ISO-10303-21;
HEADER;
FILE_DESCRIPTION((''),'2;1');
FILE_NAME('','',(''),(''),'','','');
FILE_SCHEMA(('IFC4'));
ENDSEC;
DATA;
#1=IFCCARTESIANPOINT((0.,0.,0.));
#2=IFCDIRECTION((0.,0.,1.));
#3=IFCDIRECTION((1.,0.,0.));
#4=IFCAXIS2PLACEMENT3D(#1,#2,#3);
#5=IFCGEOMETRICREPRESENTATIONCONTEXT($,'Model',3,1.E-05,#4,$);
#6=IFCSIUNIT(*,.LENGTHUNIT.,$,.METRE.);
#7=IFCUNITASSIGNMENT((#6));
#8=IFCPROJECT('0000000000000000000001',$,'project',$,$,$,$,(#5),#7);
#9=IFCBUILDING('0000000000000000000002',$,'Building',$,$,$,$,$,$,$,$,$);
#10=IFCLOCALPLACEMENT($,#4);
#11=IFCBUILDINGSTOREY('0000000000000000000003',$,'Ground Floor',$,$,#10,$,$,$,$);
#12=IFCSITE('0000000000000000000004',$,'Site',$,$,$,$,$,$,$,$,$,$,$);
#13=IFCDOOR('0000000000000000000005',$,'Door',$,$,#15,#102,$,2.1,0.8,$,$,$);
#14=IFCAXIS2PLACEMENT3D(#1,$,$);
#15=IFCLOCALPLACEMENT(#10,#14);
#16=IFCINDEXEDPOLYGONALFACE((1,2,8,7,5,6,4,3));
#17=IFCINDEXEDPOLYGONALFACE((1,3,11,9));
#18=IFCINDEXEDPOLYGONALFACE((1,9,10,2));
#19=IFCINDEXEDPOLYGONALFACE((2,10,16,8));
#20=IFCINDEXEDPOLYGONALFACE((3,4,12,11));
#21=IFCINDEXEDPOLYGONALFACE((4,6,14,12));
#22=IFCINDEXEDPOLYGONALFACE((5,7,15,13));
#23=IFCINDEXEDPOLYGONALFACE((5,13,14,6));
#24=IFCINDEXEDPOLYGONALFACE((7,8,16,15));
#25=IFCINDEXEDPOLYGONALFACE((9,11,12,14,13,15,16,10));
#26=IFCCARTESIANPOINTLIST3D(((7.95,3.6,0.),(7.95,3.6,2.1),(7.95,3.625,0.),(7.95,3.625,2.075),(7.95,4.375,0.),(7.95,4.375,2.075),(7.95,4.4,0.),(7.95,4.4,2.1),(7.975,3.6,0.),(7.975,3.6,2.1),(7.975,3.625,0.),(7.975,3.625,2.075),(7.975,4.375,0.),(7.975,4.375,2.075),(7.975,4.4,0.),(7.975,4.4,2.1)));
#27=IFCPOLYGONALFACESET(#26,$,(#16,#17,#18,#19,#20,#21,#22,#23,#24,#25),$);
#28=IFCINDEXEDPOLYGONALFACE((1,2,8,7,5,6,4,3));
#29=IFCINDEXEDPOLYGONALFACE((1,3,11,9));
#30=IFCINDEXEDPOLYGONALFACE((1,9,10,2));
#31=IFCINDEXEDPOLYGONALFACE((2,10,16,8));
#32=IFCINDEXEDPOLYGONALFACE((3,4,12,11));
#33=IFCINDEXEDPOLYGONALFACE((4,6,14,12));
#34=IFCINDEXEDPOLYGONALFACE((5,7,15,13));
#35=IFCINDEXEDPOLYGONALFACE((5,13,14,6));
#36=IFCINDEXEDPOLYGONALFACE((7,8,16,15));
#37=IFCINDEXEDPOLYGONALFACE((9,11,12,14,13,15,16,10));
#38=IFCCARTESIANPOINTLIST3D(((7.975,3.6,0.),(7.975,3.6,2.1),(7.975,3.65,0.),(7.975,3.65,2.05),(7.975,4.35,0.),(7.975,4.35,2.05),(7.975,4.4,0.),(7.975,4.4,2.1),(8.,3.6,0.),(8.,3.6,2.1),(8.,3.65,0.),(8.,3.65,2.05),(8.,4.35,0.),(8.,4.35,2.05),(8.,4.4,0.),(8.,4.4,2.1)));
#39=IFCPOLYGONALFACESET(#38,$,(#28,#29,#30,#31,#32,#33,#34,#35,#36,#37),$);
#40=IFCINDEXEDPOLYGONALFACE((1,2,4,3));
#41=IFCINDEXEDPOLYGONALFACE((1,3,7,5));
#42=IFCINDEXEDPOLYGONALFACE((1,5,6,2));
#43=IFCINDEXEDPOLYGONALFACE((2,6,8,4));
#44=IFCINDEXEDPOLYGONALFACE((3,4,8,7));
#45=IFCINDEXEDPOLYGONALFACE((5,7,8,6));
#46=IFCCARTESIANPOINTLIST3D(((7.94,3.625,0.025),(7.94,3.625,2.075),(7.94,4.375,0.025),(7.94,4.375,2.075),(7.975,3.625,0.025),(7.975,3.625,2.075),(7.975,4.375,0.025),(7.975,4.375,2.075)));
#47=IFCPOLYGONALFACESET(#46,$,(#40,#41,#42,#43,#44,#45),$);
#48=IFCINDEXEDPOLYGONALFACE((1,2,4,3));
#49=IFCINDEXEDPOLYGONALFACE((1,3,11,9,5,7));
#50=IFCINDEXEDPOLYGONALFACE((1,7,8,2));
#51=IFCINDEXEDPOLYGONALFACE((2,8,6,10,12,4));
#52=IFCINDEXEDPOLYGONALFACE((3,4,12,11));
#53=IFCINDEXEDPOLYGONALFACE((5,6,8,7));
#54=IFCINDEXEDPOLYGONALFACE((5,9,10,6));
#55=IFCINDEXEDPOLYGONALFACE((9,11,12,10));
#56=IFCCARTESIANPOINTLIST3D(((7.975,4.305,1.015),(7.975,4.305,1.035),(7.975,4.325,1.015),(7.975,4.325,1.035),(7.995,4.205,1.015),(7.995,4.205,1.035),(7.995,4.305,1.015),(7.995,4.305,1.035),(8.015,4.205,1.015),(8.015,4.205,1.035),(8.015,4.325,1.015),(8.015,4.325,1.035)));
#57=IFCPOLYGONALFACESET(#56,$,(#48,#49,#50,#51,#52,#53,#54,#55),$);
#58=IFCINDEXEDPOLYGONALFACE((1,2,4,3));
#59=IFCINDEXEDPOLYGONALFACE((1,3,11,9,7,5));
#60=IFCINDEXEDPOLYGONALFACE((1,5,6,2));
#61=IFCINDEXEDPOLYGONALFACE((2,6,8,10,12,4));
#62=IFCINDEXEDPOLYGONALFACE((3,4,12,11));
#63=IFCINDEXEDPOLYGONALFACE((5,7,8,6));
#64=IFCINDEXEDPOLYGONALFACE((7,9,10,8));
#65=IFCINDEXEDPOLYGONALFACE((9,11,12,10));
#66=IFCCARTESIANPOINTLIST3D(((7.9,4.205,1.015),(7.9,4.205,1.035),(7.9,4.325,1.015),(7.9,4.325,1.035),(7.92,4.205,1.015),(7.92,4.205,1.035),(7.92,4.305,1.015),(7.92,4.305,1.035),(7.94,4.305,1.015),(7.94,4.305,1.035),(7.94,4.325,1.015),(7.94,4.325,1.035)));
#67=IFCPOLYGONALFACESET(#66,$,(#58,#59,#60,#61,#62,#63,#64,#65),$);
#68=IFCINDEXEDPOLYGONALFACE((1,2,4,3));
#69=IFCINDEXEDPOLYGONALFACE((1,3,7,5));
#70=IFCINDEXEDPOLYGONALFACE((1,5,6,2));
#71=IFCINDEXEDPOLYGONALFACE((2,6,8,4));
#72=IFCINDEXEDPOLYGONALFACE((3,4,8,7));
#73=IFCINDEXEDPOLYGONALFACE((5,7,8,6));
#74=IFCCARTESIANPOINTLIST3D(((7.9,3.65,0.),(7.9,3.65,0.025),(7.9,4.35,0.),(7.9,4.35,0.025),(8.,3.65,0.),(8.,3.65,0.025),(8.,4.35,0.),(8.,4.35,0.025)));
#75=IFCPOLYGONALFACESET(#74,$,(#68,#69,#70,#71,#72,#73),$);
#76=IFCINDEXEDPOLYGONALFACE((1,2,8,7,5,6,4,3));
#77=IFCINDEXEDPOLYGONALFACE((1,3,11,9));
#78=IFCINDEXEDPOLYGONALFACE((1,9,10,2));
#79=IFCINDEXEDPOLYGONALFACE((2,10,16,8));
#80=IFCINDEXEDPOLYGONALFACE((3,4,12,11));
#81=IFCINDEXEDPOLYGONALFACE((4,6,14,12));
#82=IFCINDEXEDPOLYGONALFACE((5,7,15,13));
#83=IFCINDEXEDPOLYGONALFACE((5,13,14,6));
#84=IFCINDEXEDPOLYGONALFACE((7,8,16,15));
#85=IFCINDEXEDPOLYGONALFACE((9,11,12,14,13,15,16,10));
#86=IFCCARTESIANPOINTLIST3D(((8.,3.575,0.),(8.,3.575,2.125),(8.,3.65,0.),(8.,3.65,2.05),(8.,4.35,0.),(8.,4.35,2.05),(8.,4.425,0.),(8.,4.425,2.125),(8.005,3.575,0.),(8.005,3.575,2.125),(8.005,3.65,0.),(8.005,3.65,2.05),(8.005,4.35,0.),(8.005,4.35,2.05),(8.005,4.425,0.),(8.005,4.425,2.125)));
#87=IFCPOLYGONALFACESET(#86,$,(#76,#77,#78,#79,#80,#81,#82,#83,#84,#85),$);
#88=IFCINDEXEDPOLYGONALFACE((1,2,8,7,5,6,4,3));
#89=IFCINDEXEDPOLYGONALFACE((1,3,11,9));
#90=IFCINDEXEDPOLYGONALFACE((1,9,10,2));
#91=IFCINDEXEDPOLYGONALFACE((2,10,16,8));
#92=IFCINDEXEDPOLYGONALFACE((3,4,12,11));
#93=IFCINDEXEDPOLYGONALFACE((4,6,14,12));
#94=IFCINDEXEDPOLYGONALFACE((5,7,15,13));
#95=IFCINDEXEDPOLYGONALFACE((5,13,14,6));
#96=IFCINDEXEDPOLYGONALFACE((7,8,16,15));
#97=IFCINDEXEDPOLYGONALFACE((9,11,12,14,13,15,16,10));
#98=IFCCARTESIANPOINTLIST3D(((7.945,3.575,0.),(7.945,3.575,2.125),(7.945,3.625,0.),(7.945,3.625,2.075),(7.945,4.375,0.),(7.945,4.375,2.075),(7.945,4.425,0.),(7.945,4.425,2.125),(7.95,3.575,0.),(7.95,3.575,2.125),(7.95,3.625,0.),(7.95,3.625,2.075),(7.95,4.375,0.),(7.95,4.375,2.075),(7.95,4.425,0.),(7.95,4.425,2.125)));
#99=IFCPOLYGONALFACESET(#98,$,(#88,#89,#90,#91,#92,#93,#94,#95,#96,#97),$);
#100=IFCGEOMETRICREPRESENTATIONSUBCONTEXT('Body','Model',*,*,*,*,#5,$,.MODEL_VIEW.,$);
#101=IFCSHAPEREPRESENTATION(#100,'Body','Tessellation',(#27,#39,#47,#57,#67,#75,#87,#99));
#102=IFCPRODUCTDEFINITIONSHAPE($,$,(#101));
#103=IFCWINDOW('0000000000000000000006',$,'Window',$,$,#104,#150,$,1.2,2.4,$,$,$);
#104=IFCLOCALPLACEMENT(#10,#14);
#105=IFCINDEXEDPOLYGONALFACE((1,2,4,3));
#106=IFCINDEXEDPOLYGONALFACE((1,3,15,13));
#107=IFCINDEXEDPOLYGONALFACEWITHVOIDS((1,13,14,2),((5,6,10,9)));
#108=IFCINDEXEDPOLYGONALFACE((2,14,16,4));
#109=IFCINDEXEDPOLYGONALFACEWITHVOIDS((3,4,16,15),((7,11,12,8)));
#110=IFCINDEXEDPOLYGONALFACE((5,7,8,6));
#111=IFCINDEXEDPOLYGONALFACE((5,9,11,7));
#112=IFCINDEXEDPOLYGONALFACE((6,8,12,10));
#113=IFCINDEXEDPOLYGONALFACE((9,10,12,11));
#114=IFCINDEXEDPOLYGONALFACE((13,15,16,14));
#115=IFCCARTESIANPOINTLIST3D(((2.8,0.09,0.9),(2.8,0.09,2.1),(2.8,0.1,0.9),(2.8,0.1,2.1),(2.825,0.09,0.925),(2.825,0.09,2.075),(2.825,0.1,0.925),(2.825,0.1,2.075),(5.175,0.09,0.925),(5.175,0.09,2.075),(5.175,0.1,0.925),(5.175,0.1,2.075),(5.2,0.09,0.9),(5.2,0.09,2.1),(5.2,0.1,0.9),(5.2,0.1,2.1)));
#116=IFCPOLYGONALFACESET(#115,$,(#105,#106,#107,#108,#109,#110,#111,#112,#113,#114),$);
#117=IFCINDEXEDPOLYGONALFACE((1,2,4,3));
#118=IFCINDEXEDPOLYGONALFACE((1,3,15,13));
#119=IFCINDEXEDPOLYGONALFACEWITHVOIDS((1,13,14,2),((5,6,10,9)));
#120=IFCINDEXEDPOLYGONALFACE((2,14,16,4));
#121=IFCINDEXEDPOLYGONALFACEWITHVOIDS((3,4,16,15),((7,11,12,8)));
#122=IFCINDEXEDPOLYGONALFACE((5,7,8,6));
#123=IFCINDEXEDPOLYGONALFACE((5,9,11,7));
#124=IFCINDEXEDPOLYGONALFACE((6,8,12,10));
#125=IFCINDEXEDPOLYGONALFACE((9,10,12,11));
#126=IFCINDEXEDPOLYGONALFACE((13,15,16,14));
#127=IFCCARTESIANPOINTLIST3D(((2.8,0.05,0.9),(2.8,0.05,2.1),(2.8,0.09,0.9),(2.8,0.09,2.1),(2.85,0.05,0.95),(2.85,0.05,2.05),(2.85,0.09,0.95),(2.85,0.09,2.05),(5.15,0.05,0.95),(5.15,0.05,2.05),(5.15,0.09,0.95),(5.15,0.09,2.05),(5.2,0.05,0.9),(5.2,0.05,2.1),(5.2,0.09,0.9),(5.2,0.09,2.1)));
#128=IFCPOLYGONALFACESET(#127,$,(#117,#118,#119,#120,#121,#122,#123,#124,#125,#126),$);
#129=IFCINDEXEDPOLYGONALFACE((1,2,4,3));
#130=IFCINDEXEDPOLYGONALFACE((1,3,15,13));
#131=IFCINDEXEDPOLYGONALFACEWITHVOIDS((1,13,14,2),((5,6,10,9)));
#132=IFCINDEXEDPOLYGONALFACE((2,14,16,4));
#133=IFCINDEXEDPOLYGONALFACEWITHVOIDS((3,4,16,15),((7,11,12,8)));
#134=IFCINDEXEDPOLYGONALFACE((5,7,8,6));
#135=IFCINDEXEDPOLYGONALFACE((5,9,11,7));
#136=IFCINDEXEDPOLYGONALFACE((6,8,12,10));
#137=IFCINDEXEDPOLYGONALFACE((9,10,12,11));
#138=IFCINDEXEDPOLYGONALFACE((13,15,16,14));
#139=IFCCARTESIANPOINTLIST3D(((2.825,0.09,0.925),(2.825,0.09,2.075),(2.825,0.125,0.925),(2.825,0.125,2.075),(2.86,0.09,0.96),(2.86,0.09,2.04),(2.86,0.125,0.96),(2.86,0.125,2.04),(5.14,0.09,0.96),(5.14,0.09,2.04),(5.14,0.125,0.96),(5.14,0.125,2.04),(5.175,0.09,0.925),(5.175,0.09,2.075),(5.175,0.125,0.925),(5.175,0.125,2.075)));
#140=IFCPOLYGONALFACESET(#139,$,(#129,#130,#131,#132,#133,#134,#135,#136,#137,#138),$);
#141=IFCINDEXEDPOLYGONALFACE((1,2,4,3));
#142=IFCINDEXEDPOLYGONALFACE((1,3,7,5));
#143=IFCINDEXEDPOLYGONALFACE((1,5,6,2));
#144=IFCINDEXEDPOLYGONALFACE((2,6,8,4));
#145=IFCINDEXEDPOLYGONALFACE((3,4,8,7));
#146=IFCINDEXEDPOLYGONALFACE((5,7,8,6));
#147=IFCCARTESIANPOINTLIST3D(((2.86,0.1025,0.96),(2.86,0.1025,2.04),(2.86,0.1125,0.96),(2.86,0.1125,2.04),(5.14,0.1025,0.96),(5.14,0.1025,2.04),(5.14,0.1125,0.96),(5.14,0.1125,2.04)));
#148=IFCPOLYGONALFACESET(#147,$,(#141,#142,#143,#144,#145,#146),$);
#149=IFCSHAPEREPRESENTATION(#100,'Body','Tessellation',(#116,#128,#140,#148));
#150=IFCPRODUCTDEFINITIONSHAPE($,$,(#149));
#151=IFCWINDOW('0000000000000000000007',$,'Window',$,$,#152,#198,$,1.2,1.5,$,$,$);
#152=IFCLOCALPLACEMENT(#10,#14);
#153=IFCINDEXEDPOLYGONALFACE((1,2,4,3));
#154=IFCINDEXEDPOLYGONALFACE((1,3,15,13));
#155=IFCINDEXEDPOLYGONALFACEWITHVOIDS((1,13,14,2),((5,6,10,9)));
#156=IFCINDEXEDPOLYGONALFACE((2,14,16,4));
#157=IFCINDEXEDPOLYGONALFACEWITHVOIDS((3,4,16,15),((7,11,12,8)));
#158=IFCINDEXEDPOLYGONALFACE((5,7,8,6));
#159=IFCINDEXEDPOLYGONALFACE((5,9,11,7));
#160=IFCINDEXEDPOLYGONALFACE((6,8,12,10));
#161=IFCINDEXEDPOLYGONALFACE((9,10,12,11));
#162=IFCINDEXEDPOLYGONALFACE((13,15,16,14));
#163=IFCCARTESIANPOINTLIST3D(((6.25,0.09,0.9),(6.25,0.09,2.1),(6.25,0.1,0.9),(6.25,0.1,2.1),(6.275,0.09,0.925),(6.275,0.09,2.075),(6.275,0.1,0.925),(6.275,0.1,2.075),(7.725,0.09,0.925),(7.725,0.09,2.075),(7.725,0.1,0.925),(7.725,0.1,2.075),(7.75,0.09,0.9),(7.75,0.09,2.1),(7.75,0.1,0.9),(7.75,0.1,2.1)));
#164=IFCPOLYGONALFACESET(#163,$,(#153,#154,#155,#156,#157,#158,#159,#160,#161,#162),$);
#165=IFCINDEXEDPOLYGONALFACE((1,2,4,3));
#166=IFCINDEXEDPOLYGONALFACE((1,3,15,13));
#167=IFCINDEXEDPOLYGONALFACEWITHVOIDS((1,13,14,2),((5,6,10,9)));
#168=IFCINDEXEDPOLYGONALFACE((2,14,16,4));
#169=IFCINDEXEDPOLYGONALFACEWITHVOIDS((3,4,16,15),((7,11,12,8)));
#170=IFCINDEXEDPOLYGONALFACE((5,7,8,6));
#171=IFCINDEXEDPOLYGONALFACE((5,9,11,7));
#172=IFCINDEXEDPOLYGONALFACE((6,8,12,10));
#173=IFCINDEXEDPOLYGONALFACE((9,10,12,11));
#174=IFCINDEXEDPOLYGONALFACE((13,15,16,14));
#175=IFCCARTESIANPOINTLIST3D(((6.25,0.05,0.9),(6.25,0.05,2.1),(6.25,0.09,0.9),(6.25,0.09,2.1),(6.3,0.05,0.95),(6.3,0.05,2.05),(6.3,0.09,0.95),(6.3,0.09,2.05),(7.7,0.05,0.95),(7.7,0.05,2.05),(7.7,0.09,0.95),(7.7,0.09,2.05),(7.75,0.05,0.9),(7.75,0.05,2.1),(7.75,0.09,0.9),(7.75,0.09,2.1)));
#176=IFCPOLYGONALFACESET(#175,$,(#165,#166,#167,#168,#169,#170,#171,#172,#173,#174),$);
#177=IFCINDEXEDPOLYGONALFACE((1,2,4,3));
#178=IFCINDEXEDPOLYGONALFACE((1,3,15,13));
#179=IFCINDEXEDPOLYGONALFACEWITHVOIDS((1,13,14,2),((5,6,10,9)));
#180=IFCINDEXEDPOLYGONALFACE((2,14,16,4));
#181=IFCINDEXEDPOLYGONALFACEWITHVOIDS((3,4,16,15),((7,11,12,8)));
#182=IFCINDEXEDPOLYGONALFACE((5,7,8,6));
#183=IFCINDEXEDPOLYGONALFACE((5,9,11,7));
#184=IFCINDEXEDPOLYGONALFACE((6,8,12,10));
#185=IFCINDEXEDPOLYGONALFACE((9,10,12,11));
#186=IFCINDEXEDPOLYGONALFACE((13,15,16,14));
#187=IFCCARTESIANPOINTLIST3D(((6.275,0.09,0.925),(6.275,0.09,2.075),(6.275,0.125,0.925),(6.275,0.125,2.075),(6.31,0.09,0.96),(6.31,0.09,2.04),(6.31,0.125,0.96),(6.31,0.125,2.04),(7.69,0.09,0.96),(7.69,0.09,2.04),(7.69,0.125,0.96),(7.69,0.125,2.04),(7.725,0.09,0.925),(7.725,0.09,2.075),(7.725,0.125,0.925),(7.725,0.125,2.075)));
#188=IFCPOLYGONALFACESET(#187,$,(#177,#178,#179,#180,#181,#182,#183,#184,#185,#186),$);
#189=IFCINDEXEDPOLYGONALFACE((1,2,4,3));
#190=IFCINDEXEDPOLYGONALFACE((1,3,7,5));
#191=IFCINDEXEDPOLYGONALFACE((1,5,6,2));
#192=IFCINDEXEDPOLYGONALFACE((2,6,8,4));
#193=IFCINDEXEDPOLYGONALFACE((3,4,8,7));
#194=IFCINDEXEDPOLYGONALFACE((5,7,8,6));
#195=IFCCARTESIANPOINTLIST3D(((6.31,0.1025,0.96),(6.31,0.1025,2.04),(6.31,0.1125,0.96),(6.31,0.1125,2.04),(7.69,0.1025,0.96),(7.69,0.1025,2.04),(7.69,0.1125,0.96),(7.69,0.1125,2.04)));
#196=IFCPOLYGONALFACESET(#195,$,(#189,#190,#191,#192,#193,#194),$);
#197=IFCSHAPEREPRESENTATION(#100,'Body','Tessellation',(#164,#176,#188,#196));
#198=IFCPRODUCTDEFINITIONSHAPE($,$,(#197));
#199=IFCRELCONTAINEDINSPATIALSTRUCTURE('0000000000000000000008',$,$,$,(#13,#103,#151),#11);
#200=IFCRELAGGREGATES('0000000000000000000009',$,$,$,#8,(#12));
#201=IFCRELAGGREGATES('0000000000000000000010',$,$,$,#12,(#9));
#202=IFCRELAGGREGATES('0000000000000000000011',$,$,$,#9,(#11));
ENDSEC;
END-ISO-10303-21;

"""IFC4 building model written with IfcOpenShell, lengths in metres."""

from ifc_helpers import new_model, si_unit, frame, origin_with_axes, place, context, subcontext, project, spatial, line, indexed_curve, outline, extrude, element, save


model = new_model("IFC4")

# Units and contexts
model_context = context("Model", 3, precision=1e-05, world=origin_with_axes())
body_context = subcontext(model_context, "Body", "Model", "MODEL_VIEW")
ifc_project = project(units=[si_unit("LENGTHUNIT", "METRE")], contexts=[model_context])

# Site, building, storey
site = spatial("IfcSite", under=ifc_project, Name="Site")
building = spatial("IfcBuilding", under=site, Name="Building")
storey_placement = place(None, origin_with_axes())
storey = spatial("IfcBuildingStorey", under=building, at=storey_placement, Name="Ground Floor")

# Door
door_1_placement = place(storey_placement, frame((8.0, 3.6, 0.0), z_axis=(0.0, 0.0, 1.0), x_axis=(0.0, 1.0, 0.0)))
element("IfcDoor", 1, at=door_1_placement, inside=storey, Name="Door", OverallHeight=2.1, OverallWidth=0.8, context=body_context, shape_type="SweptSolid", body=[
    extrude(outline(indexed_curve([(0.0, 0.0), (0.0, 2.1), (0.8, 2.1), (0.8, 0.0), (0.775, 0.0), (0.775, 2.075), (0.025, 2.075), (0.025, 0.0)], segments=[line(1, 2, 3, 4, 5, 6, 7, 8, 1)])), frame((0.0, 0.025, 0.0), z_axis=(0.0, -1.0, 0.0), x_axis=(1.0, 0.0, 0.0)), (0.0, 0.0, -1.0), 0.025),
    extrude(outline(indexed_curve([(0.0, 0.0), (0.0, 2.1), (0.8, 2.1), (0.8, 0.0), (0.75, 0.0), (0.75, 2.05), (0.05, 2.05), (0.05, 0.0)], segments=[line(1, 2, 3, 4, 5, 6, 7, 8, 1)])), frame((0.0, 0.0, 0.0), z_axis=(0.0, -1.0, 0.0), x_axis=(1.0, 0.0, 0.0)), (0.0, 0.0, -1.0), 0.025),
    extrude(outline(indexed_curve([(0.0, 0.0), (0.75, 0.0), (0.75, 0.035), (0.0, 0.035)], segments=[line(1, 2, 3, 4, 1)])), frame((0.025, 0.025, 0.025), z_axis=(0.0, 0.0, 1.0), x_axis=(1.0, 0.0, 0.0)), (0.0, 0.0, 1.0), 2.05),
    extrude(outline(indexed_curve([(0.0, 0.0), (0.0, -0.04), (-0.12, -0.04), (-0.12, -0.02), (-0.02, -0.02), (-0.02, 0.0)], segments=[line(1, 2, 3, 4, 5, 6, 1)])), frame((0.725, 0.025, 1.015), z_axis=(0.0, 0.0, 1.0), x_axis=(1.0, 0.0, 0.0)), (0.0, 0.0, 1.0), 0.02),
    extrude(outline(indexed_curve([(0.0, 0.0), (0.0, 0.04), (-0.12, 0.04), (-0.12, 0.02), (-0.02, 0.02), (-0.02, 0.0)], segments=[line(1, 2, 3, 4, 5, 6, 1)])), frame((0.725, 0.06, 1.015), z_axis=(0.0, 0.0, 1.0), x_axis=(1.0, 0.0, 0.0)), (0.0, 0.0, 1.0), 0.02),
    extrude(outline(indexed_curve([(0.0, 0.0), (0.7, 0.0), (0.7, 0.1), (0.0, 0.1)], segments=[line(1, 2, 3, 4, 1)])), frame((0.05, 0.0, 0.0), z_axis=(0.0, 0.0, 1.0), x_axis=(1.0, 0.0, 0.0)), (0.0, 0.0, 1.0), 0.025),
    extrude(outline(indexed_curve([(0.0, 0.0), (0.0, 2.125), (0.85, 2.125), (0.85, 0.0), (0.775, 0.0), (0.775, 2.05), (0.075, 2.05), (0.075, 0.0)], segments=[line(1, 2, 3, 4, 5, 6, 7, 8, 1)])), frame((-0.025, -0.005, 0.0), z_axis=(0.0, -1.0, 0.0), x_axis=(1.0, 0.0, 0.0)), (0.0, 0.0, -1.0), 0.005),
    extrude(outline(indexed_curve([(0.0, 0.0), (0.0, 2.125), (0.85, 2.125), (0.85, 0.0), (0.8, 0.0), (0.8, 2.075), (0.05, 2.075), (0.05, 0.0)], segments=[line(1, 2, 3, 4, 5, 6, 7, 8, 1)])), frame((-0.025, 0.05, 0.0), z_axis=(0.0, -1.0, 0.0), x_axis=(1.0, 0.0, 0.0)), (0.0, 0.0, -1.0), 0.005),
])

# Windows
window_1_placement = place(storey_placement, frame((2.8, 0.0, 0.9), z_axis=(0.0, 0.0, 1.0), x_axis=(1.0, 0.0, 0.0)))
element("IfcWindow", 2, at=window_1_placement, inside=storey, Name="Window", OverallHeight=1.2, OverallWidth=2.4, context=body_context, shape_type="SweptSolid", body=[
    extrude(outline(indexed_curve([(0.0, 0.0), (2.4, 0.0), (2.4, 1.2), (0.0, 1.2)], segments=[line(1, 2, 3, 4, 1)]), holes=[indexed_curve([(0.025, 0.025), (2.375, 0.025), (2.375, 1.175), (0.025, 1.175)], segments=[line(1, 2, 3, 4, 1)])]), frame((0.0, 0.09, 0.0), z_axis=(0.0, -1.0, 0.0), x_axis=(1.0, 0.0, 0.0)), (0.0, 0.0, -1.0), 0.01),
    extrude(outline(indexed_curve([(0.0, 0.0), (2.4, 0.0), (2.4, 1.2), (0.0, 1.2)], segments=[line(1, 2, 3, 4, 1)]), holes=[indexed_curve([(0.05, 0.05), (2.35, 0.05), (2.35, 1.15), (0.05, 1.15)], segments=[line(1, 2, 3, 4, 1)])]), frame((0.0, 0.05, 0.0), z_axis=(0.0, -1.0, 0.0), x_axis=(1.0, 0.0, 0.0)), (0.0, 0.0, -1.0), 0.04),
    extrude(outline(indexed_curve([(0.0, 0.0), (2.35, 0.0), (2.35, 1.15), (0.0, 1.15)], segments=[line(1, 2, 3, 4, 1)]), holes=[indexed_curve([(0.035, 0.035), (2.315, 0.035), (2.315, 1.115), (0.035, 1.115)], segments=[line(1, 2, 3, 4, 1)])]), frame((0.025, 0.09, 0.025), z_axis=(0.0, -1.0, 0.0), x_axis=(1.0, 0.0, 0.0)), (0.0, 0.0, -1.0), 0.035),
    extrude(outline(indexed_curve([(0.035, 0.035), (2.315, 0.035), (2.315, 1.115), (0.035, 1.115)], segments=[line(1, 2, 3, 4, 1)])), frame((0.025, 0.1025, 0.025), z_axis=(0.0, -1.0, 0.0), x_axis=(1.0, 0.0, 0.0)), (0.0, 0.0, -1.0), 0.01),
])
window_2_placement = place(storey_placement, frame((6.25, 0.0, 0.9), z_axis=(0.0, 0.0, 1.0), x_axis=(1.0, 0.0, 0.0)))
element("IfcWindow", 3, at=window_2_placement, inside=storey, Name="Window", OverallHeight=1.2, OverallWidth=1.5, context=body_context, shape_type="SweptSolid", body=[
    extrude(outline(indexed_curve([(0.0, 0.0), (1.5, 0.0), (1.5, 1.2), (0.0, 1.2)], segments=[line(1, 2, 3, 4, 1)]), holes=[indexed_curve([(0.025, 0.025), (1.475, 0.025), (1.475, 1.175), (0.025, 1.175)], segments=[line(1, 2, 3, 4, 1)])]), frame((0.0, 0.09, 0.0), z_axis=(0.0, -1.0, 0.0), x_axis=(1.0, 0.0, 0.0)), (0.0, 0.0, -1.0), 0.01),
    extrude(outline(indexed_curve([(0.0, 0.0), (1.5, 0.0), (1.5, 1.2), (0.0, 1.2)], segments=[line(1, 2, 3, 4, 1)]), holes=[indexed_curve([(0.05, 0.05), (1.45, 0.05), (1.45, 1.15), (0.05, 1.15)], segments=[line(1, 2, 3, 4, 1)])]), frame((0.0, 0.05, 0.0), z_axis=(0.0, -1.0, 0.0), x_axis=(1.0, 0.0, 0.0)), (0.0, 0.0, -1.0), 0.04),
    extrude(outline(indexed_curve([(0.0, 0.0), (1.45, 0.0), (1.45, 1.15), (0.0, 1.15)], segments=[line(1, 2, 3, 4, 1)]), holes=[indexed_curve([(0.035, 0.035), (1.415, 0.035), (1.415, 1.115), (0.035, 1.115)], segments=[line(1, 2, 3, 4, 1)])]), frame((0.025, 0.09, 0.025), z_axis=(0.0, -1.0, 0.0), x_axis=(1.0, 0.0, 0.0)), (0.0, 0.0, -1.0), 0.035),
    extrude(outline(indexed_curve([(0.035, 0.035), (1.415, 0.035), (1.415, 1.115), (0.035, 1.115)], segments=[line(1, 2, 3, 4, 1)])), frame((0.025, 0.1025, 0.025), z_axis=(0.0, -1.0, 0.0), x_axis=(1.0, 0.0, 0.0)), (0.0, 0.0, -1.0), 0.01),
])

save(model, "model.ifc")
